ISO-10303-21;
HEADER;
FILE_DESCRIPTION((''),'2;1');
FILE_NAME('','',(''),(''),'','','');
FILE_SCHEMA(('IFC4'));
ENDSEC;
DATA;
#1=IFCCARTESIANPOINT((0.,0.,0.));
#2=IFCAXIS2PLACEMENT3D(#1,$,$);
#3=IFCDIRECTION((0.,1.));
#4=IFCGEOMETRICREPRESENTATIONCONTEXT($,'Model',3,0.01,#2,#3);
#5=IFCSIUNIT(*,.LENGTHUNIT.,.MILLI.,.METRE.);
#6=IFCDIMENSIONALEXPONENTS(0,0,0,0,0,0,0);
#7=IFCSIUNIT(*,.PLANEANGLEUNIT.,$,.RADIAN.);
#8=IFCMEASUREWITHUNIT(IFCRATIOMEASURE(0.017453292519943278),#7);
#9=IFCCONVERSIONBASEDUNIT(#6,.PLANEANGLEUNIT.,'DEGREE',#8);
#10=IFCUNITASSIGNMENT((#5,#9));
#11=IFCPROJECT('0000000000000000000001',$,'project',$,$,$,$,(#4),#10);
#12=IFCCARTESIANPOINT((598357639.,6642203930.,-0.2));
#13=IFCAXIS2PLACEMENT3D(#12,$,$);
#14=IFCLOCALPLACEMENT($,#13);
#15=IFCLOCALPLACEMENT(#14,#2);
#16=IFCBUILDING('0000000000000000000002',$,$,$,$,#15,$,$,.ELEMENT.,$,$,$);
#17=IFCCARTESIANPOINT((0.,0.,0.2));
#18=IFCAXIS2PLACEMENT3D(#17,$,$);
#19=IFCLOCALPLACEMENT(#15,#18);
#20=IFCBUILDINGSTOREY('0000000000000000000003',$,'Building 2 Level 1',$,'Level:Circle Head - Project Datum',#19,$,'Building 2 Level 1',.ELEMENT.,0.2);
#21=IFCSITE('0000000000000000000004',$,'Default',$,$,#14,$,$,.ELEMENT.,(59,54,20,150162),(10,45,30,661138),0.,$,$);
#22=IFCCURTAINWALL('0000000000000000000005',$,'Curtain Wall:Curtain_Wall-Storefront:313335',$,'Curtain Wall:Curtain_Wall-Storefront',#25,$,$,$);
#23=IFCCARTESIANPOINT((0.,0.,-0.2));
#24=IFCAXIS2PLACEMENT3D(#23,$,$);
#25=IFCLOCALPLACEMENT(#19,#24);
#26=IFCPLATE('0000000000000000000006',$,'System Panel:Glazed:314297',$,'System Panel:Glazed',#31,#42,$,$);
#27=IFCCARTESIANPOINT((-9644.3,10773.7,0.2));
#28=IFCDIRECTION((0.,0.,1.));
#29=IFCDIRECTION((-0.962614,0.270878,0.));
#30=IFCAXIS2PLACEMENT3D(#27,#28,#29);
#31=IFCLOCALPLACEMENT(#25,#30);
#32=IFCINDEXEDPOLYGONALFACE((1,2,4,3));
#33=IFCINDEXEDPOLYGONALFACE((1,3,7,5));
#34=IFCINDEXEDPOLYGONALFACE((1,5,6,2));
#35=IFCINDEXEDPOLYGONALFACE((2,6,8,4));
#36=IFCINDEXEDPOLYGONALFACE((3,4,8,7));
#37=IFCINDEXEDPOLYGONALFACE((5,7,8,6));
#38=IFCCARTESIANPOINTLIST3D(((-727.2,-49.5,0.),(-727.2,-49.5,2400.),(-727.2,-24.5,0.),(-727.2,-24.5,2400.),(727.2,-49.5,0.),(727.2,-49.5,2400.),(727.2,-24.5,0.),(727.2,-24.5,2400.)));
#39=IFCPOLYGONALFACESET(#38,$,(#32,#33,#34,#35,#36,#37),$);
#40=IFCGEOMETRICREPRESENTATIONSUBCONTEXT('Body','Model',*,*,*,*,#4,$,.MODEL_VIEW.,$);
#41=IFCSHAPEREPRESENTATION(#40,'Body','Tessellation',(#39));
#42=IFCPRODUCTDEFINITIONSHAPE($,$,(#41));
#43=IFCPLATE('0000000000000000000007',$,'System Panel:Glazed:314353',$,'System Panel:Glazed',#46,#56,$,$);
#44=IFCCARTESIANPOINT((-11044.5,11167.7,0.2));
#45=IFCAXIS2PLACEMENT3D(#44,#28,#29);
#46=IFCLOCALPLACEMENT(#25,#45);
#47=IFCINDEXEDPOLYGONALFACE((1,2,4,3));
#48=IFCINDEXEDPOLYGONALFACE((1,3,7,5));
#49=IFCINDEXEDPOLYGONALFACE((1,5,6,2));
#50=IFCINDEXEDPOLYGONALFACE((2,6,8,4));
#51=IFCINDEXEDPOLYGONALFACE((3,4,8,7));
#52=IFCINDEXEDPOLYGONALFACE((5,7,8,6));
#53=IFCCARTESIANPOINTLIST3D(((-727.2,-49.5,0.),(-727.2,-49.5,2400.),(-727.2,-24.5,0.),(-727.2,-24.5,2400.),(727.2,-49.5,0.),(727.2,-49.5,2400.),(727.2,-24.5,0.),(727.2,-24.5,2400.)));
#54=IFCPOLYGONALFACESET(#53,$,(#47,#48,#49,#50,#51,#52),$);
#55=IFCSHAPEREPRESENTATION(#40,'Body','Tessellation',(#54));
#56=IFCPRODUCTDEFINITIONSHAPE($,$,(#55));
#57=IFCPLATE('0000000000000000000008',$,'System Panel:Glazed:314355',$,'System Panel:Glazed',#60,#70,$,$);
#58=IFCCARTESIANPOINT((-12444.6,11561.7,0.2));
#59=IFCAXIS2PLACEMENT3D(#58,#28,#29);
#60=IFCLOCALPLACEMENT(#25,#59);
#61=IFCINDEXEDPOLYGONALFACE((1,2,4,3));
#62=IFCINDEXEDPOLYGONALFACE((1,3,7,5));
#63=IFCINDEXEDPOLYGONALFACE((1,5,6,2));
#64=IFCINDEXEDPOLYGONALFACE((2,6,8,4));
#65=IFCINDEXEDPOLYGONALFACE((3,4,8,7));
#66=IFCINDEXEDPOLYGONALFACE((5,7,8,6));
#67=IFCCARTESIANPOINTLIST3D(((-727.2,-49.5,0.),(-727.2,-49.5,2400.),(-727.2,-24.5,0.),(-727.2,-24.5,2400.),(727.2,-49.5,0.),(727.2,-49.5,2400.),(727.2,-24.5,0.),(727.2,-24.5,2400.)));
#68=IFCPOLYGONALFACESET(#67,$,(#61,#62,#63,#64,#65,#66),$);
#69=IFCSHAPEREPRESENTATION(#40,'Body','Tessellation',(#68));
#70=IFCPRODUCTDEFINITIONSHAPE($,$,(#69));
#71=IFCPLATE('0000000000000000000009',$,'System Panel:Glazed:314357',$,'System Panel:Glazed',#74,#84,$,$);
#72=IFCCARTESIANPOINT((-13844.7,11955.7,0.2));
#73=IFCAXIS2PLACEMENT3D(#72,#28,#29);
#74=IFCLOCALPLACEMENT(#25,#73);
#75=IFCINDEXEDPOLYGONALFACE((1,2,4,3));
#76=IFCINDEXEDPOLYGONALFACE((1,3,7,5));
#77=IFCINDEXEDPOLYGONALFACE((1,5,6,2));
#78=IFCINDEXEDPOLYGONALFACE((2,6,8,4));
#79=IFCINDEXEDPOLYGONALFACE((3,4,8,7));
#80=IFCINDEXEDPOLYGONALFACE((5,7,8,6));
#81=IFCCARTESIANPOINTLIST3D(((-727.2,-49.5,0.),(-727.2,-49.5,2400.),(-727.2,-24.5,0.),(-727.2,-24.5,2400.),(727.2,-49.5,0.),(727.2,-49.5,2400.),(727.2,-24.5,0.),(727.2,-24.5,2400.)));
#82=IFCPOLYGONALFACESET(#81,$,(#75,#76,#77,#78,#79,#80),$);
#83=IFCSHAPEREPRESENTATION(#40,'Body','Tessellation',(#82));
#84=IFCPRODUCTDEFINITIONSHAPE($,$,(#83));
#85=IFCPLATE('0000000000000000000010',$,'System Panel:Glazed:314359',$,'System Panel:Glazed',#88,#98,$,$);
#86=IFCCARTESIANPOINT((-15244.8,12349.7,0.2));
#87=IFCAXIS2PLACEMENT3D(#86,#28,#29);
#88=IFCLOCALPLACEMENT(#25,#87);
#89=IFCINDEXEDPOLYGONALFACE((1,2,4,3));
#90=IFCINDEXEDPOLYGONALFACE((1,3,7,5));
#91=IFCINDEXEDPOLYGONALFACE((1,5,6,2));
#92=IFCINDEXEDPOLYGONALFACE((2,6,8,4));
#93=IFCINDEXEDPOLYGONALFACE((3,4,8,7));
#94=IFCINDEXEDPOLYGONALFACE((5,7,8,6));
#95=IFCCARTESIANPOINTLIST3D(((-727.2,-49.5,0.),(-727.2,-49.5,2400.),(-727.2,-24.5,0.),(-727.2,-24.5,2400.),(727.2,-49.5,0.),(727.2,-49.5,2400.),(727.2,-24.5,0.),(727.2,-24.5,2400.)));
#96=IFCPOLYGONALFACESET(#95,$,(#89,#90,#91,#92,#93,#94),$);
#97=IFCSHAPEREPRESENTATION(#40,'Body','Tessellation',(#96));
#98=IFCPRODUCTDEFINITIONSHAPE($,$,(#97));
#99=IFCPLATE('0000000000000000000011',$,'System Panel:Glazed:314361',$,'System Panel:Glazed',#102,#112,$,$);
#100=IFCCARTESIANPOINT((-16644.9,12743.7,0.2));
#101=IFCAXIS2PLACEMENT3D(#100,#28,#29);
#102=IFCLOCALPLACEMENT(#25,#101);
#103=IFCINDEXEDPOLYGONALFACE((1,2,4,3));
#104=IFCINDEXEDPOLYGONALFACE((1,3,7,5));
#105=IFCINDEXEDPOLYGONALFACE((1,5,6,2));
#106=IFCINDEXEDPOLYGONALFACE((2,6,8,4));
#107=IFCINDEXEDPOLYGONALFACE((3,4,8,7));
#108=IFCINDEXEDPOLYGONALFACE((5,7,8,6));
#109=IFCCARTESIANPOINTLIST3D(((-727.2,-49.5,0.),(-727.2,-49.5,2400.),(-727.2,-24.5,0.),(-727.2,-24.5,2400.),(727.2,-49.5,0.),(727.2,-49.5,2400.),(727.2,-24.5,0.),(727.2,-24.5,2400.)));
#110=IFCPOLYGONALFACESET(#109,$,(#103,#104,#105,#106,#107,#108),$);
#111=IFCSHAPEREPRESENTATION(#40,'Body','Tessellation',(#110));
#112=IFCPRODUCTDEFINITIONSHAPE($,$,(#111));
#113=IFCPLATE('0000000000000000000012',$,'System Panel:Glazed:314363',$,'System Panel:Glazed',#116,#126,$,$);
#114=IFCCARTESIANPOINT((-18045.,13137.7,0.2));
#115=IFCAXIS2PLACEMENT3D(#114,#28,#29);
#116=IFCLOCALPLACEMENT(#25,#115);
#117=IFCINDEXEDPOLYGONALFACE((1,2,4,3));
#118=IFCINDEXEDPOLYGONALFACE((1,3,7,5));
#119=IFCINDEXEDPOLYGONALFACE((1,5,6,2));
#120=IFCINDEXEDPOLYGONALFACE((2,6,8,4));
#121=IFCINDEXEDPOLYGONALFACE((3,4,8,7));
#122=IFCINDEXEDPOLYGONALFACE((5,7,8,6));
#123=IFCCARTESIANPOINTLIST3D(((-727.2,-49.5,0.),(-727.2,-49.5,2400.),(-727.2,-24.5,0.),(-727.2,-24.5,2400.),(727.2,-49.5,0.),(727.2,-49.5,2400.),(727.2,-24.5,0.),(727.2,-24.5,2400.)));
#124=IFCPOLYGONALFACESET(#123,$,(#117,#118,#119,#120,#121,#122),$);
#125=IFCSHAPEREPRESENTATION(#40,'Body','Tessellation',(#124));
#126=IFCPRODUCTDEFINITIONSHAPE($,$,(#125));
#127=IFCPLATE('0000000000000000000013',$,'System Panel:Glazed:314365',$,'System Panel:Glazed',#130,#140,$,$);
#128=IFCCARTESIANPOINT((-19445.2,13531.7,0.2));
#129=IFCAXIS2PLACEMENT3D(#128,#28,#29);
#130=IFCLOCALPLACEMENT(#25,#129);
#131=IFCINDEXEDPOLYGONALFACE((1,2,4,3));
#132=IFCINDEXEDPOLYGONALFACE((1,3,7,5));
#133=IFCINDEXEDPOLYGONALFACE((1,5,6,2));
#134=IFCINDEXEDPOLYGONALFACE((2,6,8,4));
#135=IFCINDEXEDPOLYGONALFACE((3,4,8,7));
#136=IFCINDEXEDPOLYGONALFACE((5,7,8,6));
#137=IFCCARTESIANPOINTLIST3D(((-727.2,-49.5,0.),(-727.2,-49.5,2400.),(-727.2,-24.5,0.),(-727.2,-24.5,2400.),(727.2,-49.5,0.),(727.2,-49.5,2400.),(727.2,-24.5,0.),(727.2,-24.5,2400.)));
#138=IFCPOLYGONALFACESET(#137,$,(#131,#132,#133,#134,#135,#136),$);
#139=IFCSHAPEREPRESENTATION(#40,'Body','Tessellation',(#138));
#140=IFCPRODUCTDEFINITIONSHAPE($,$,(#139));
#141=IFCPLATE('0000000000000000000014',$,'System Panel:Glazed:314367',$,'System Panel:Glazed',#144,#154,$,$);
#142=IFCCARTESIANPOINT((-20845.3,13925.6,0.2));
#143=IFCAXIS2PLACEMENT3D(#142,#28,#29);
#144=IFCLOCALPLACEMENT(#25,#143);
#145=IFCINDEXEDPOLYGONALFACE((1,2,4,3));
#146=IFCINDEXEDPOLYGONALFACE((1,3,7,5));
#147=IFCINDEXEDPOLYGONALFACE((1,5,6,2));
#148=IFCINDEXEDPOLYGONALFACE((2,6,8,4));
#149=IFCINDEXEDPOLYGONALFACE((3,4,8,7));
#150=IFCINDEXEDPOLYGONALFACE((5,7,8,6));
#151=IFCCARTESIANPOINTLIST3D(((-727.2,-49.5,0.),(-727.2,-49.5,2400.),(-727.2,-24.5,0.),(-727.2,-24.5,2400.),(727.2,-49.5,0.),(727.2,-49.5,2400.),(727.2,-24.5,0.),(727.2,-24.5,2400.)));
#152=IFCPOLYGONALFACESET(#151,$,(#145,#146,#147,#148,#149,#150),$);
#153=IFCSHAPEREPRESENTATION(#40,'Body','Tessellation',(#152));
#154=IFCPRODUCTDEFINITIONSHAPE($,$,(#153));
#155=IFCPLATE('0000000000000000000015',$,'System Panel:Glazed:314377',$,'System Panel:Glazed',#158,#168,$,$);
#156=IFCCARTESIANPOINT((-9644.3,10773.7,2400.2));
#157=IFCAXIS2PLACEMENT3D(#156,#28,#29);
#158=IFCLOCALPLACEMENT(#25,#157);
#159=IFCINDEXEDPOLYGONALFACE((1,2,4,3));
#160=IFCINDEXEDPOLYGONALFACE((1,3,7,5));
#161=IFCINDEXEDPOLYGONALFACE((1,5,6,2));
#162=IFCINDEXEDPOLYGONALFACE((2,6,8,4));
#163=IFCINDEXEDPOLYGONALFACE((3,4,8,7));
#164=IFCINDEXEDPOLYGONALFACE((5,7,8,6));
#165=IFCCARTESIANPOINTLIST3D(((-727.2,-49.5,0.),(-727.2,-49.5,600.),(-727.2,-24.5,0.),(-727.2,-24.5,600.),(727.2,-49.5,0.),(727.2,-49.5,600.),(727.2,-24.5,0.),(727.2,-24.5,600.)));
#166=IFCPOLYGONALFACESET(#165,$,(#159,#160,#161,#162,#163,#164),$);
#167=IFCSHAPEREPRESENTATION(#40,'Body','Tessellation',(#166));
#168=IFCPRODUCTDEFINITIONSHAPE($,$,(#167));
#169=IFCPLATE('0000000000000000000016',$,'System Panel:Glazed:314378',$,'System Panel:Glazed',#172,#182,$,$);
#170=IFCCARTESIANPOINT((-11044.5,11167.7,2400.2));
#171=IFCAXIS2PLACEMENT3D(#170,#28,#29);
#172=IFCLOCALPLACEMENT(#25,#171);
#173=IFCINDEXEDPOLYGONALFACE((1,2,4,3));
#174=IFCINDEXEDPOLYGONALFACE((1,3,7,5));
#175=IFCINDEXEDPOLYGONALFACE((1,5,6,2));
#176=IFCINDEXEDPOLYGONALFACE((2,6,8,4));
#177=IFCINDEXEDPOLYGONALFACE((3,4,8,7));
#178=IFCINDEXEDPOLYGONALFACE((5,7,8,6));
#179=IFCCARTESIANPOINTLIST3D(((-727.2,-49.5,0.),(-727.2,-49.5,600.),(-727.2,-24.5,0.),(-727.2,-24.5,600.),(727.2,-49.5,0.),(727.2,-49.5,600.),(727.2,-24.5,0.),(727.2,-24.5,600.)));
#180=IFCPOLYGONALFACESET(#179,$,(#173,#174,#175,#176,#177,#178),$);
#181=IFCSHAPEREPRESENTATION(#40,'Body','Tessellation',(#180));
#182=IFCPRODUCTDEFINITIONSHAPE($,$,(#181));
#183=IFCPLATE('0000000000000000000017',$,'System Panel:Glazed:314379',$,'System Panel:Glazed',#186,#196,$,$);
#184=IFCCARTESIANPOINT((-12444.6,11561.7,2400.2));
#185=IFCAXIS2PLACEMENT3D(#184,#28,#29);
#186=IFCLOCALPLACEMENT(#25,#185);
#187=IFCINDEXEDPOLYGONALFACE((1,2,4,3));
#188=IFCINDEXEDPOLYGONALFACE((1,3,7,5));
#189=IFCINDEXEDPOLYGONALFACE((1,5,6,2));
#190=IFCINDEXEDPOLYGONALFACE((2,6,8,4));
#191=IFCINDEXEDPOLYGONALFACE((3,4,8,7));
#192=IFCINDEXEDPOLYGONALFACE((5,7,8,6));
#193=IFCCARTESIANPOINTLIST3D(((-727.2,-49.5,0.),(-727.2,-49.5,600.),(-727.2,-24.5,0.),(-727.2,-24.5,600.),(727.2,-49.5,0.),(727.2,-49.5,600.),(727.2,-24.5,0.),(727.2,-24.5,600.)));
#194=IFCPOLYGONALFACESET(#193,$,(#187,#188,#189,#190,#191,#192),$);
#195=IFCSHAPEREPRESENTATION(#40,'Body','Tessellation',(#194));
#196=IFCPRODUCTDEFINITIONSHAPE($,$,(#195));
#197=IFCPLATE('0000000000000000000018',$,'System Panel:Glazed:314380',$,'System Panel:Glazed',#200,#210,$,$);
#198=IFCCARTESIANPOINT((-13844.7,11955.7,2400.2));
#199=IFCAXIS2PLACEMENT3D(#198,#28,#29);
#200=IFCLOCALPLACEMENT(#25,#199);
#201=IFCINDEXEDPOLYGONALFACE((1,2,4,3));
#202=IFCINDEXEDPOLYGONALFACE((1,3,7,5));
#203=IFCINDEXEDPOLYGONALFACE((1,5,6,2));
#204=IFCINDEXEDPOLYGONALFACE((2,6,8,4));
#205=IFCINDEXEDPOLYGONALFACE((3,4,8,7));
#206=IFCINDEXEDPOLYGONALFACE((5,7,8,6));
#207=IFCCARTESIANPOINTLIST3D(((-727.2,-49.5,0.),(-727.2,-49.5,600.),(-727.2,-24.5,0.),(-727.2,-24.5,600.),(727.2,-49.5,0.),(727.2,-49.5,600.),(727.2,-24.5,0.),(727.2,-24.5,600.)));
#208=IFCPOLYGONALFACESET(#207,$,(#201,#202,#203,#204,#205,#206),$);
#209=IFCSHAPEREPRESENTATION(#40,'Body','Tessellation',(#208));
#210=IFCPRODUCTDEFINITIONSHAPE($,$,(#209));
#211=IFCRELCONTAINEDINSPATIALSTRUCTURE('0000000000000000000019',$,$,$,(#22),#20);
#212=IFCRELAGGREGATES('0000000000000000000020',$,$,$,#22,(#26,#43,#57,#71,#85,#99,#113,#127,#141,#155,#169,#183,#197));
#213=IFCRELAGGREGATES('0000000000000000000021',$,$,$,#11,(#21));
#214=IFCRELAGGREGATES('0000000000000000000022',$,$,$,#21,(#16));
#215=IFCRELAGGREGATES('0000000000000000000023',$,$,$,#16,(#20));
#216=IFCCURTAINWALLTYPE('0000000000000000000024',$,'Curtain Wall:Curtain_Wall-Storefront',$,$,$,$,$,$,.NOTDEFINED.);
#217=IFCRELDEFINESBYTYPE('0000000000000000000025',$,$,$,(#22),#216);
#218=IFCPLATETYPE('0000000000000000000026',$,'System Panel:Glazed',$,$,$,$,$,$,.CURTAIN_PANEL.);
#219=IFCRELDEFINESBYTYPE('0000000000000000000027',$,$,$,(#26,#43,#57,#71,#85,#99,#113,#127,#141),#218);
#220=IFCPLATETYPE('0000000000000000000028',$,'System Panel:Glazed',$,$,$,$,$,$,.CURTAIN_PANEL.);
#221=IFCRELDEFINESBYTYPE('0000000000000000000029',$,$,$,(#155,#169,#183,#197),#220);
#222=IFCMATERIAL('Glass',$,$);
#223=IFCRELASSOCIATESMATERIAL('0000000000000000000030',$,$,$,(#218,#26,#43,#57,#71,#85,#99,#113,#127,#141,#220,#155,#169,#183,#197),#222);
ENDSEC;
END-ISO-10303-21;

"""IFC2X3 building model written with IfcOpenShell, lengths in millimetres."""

from ifc_helpers import new_model, entity, si_unit, converted_unit, direction, frame, frame_2d, origin, place, context, subcontext, project, spatial, rectangle, extrude, source, transform, mapped, material, type_object, type_shapes, element, aggregate, save


model = new_model("IFC2X3")

# Units and contexts
model_context = context("Model", 3, precision=0.01, world=origin(), true_north=direction((0.0, 1.0)))
body_context = subcontext(model_context, "Body", "Model", "MODEL_VIEW")
ifc_project = project(units=[si_unit("LENGTHUNIT", "METRE", prefix="MILLI"), converted_unit("PLANEANGLEUNIT", "DEGREE", entity("IfcRatioMeasure", 0.017453292519943278), si_unit("PLANEANGLEUNIT", "RADIAN"), dimensions=[0, 0, 0, 0, 0, 0, 0])], contexts=[model_context])

# Site, building, storey
site_placement = place(None, frame((598357639.0, 6642203930.0, -0.2)))
site = spatial("IfcSite", under=ifc_project, at=site_placement, Name="Default", CompositionType="ELEMENT", RefLatitude=(59, 54, 20, 150162), RefLongitude=(10, 45, 30, 661138), RefElevation=0.0)
building_placement = place(site_placement, origin())
building = spatial("IfcBuilding", under=site, at=building_placement, CompositionType="ELEMENT")
storey_placement = place(building_placement, frame((0.0, 0.0, 0.2)))
storey = spatial("IfcBuildingStorey", under=building, at=storey_placement, Name="Building 2 Level 1", ObjectType="Level:Circle Head - Project Datum", LongName="Building 2 Level 1", CompositionType="ELEMENT", Elevation=0.2)

# Curtain wall, plates
curtain_wall_type = type_object("IfcCurtainWallType", Name="Curtain Wall:Curtain_Wall-Storefront", PredefinedType="NOTDEFINED")
curtain_wall_1_placement = place(storey_placement, frame((0.0, 0.0, -0.2)))
curtain_wall_1 = element("IfcCurtainWall", 1, at=curtain_wall_1_placement, inside=storey, type_object=curtain_wall_type, Name="Curtain Wall:Curtain_Wall-Storefront:313335", ObjectType="Curtain Wall:Curtain_Wall-Storefront")
ifc_material = material(Name="Glass")
plate_type_1 = type_object("IfcPlateType", Name="System Panel:Glazed", PredefinedType="CURTAIN_PANEL", material=ifc_material)
shared_shape_1 = source(origin(), body_context, "Body", "SweptSolid", [
    extrude(rectangle(XDim=25.0, YDim=1454.5, at=frame_2d((0.0, 0.0), x_axis=(1.0, 0.0))), frame((0.0, -37.0, 0.0), z_axis=(0.0, 0.0, 1.0), x_axis=(0.0, 1.0, 0.0)), (0.0, 0.0, 1.0), 2400.0),
])
type_shapes(plate_type_1, [shared_shape_1])
plate_1_placement = place(curtain_wall_1_placement, frame((-9644.3, 10773.7, 0.2), z_axis=(0.0, 0.0, 1.0), x_axis=(-0.962614, 0.270878, 0.0)))
plate_1 = element("IfcPlate", 2, at=plate_1_placement, type_object=plate_type_1, material=ifc_material, Name="System Panel:Glazed:314297", ObjectType="System Panel:Glazed", context=body_context, shape_type="MappedRepresentation", body=[
    mapped(shared_shape_1, transform((0.0, 0.0, 0.0), scale=1.0)),
])
plate_2_placement = place(curtain_wall_1_placement, frame((-11044.5, 11167.7, 0.2), z_axis=(0.0, 0.0, 1.0), x_axis=(-0.962614, 0.270878, 0.0)))
plate_2 = element("IfcPlate", 3, at=plate_2_placement, type_object=plate_type_1, material=ifc_material, Name="System Panel:Glazed:314353", ObjectType="System Panel:Glazed", context=body_context, shape_type="MappedRepresentation", body=[
    mapped(shared_shape_1, transform((0.0, 0.0, 0.0), scale=1.0)),
])
plate_3_placement = place(curtain_wall_1_placement, frame((-12444.6, 11561.7, 0.2), z_axis=(0.0, 0.0, 1.0), x_axis=(-0.962614, 0.270878, 0.0)))
plate_3 = element("IfcPlate", 4, at=plate_3_placement, type_object=plate_type_1, material=ifc_material, Name="System Panel:Glazed:314355", ObjectType="System Panel:Glazed", context=body_context, shape_type="MappedRepresentation", body=[
    mapped(shared_shape_1, transform((0.0, 0.0, 0.0), scale=1.0)),
])
plate_4_placement = place(curtain_wall_1_placement, frame((-13844.7, 11955.7, 0.2), z_axis=(0.0, 0.0, 1.0), x_axis=(-0.962614, 0.270878, 0.0)))
plate_4 = element("IfcPlate", 5, at=plate_4_placement, type_object=plate_type_1, material=ifc_material, Name="System Panel:Glazed:314357", ObjectType="System Panel:Glazed", context=body_context, shape_type="MappedRepresentation", body=[
    mapped(shared_shape_1, transform((0.0, 0.0, 0.0), scale=1.0)),
])
plate_5_placement = place(curtain_wall_1_placement, frame((-15244.8, 12349.7, 0.2), z_axis=(0.0, 0.0, 1.0), x_axis=(-0.962614, 0.270878, 0.0)))
plate_5 = element("IfcPlate", 6, at=plate_5_placement, type_object=plate_type_1, material=ifc_material, Name="System Panel:Glazed:314359", ObjectType="System Panel:Glazed", context=body_context, shape_type="MappedRepresentation", body=[
    mapped(shared_shape_1, transform((0.0, 0.0, 0.0), scale=1.0)),
])
plate_6_placement = place(curtain_wall_1_placement, frame((-16644.9, 12743.7, 0.2), z_axis=(0.0, 0.0, 1.0), x_axis=(-0.962614, 0.270878, 0.0)))
plate_6 = element("IfcPlate", 7, at=plate_6_placement, type_object=plate_type_1, material=ifc_material, Name="System Panel:Glazed:314361", ObjectType="System Panel:Glazed", context=body_context, shape_type="MappedRepresentation", body=[
    mapped(shared_shape_1, transform((0.0, 0.0, 0.0), scale=1.0)),
])
plate_7_placement = place(curtain_wall_1_placement, frame((-18045.0, 13137.7, 0.2), z_axis=(0.0, 0.0, 1.0), x_axis=(-0.962614, 0.270878, 0.0)))
plate_7 = element("IfcPlate", 8, at=plate_7_placement, type_object=plate_type_1, material=ifc_material, Name="System Panel:Glazed:314363", ObjectType="System Panel:Glazed", context=body_context, shape_type="MappedRepresentation", body=[
    mapped(shared_shape_1, transform((0.0, 0.0, 0.0), scale=1.0)),
])
plate_8_placement = place(curtain_wall_1_placement, frame((-19445.2, 13531.7, 0.2), z_axis=(0.0, 0.0, 1.0), x_axis=(-0.962614, 0.270878, 0.0)))
plate_8 = element("IfcPlate", 9, at=plate_8_placement, type_object=plate_type_1, material=ifc_material, Name="System Panel:Glazed:314365", ObjectType="System Panel:Glazed", context=body_context, shape_type="MappedRepresentation", body=[
    mapped(shared_shape_1, transform((0.0, 0.0, 0.0), scale=1.0)),
])
plate_9_placement = place(curtain_wall_1_placement, frame((-20845.3, 13925.6, 0.2), z_axis=(0.0, 0.0, 1.0), x_axis=(-0.962614, 0.270878, 0.0)))
plate_9 = element("IfcPlate", 10, at=plate_9_placement, type_object=plate_type_1, material=ifc_material, Name="System Panel:Glazed:314367", ObjectType="System Panel:Glazed", context=body_context, shape_type="MappedRepresentation", body=[
    mapped(shared_shape_1, transform((0.0, 0.0, 0.0), scale=1.0)),
])
plate_type_2 = type_object("IfcPlateType", Name="System Panel:Glazed", PredefinedType="CURTAIN_PANEL", material=ifc_material)
shared_shape_2 = source(origin(), body_context, "Body", "SweptSolid", [
    extrude(rectangle(XDim=25.0, YDim=1454.5, at=frame_2d((0.0, 0.0), x_axis=(1.0, 0.0))), frame((0.0, -37.0, 0.0), z_axis=(0.0, 0.0, 1.0), x_axis=(0.0, 1.0, 0.0)), (0.0, 0.0, 1.0), 600.0),
])
type_shapes(plate_type_2, [shared_shape_2])
plate_10_placement = place(curtain_wall_1_placement, frame((-9644.3, 10773.7, 2400.2), z_axis=(0.0, 0.0, 1.0), x_axis=(-0.962614, 0.270878, 0.0)))
plate_10 = element("IfcPlate", 11, at=plate_10_placement, type_object=plate_type_2, material=ifc_material, Name="System Panel:Glazed:314377", ObjectType="System Panel:Glazed", context=body_context, shape_type="MappedRepresentation", body=[
    mapped(shared_shape_2, transform((0.0, 0.0, 0.0), scale=1.0)),
])
plate_11_placement = place(curtain_wall_1_placement, frame((-11044.5, 11167.7, 2400.2), z_axis=(0.0, 0.0, 1.0), x_axis=(-0.962614, 0.270878, 0.0)))
plate_11 = element("IfcPlate", 12, at=plate_11_placement, type_object=plate_type_2, material=ifc_material, Name="System Panel:Glazed:314378", ObjectType="System Panel:Glazed", context=body_context, shape_type="MappedRepresentation", body=[
    mapped(shared_shape_2, transform((0.0, 0.0, 0.0), scale=1.0)),
])
plate_12_placement = place(curtain_wall_1_placement, frame((-12444.6, 11561.7, 2400.2), z_axis=(0.0, 0.0, 1.0), x_axis=(-0.962614, 0.270878, 0.0)))
plate_12 = element("IfcPlate", 13, at=plate_12_placement, type_object=plate_type_2, material=ifc_material, Name="System Panel:Glazed:314379", ObjectType="System Panel:Glazed", context=body_context, shape_type="MappedRepresentation", body=[
    mapped(shared_shape_2, transform((0.0, 0.0, 0.0), scale=1.0)),
])
plate_13_placement = place(curtain_wall_1_placement, frame((-13844.7, 11955.7, 2400.2), z_axis=(0.0, 0.0, 1.0), x_axis=(-0.962614, 0.270878, 0.0)))
plate_13 = element("IfcPlate", 14, at=plate_13_placement, type_object=plate_type_2, material=ifc_material, Name="System Panel:Glazed:314380", ObjectType="System Panel:Glazed", context=body_context, shape_type="MappedRepresentation", body=[
    mapped(shared_shape_2, transform((0.0, 0.0, 0.0), scale=1.0)),
])
aggregate(curtain_wall_1, [plate_1, plate_2, plate_3, plate_4, plate_5, plate_6, plate_7, plate_8, plate_9, plate_10, plate_11, plate_12, plate_13])

save(model, "model.ifc")
